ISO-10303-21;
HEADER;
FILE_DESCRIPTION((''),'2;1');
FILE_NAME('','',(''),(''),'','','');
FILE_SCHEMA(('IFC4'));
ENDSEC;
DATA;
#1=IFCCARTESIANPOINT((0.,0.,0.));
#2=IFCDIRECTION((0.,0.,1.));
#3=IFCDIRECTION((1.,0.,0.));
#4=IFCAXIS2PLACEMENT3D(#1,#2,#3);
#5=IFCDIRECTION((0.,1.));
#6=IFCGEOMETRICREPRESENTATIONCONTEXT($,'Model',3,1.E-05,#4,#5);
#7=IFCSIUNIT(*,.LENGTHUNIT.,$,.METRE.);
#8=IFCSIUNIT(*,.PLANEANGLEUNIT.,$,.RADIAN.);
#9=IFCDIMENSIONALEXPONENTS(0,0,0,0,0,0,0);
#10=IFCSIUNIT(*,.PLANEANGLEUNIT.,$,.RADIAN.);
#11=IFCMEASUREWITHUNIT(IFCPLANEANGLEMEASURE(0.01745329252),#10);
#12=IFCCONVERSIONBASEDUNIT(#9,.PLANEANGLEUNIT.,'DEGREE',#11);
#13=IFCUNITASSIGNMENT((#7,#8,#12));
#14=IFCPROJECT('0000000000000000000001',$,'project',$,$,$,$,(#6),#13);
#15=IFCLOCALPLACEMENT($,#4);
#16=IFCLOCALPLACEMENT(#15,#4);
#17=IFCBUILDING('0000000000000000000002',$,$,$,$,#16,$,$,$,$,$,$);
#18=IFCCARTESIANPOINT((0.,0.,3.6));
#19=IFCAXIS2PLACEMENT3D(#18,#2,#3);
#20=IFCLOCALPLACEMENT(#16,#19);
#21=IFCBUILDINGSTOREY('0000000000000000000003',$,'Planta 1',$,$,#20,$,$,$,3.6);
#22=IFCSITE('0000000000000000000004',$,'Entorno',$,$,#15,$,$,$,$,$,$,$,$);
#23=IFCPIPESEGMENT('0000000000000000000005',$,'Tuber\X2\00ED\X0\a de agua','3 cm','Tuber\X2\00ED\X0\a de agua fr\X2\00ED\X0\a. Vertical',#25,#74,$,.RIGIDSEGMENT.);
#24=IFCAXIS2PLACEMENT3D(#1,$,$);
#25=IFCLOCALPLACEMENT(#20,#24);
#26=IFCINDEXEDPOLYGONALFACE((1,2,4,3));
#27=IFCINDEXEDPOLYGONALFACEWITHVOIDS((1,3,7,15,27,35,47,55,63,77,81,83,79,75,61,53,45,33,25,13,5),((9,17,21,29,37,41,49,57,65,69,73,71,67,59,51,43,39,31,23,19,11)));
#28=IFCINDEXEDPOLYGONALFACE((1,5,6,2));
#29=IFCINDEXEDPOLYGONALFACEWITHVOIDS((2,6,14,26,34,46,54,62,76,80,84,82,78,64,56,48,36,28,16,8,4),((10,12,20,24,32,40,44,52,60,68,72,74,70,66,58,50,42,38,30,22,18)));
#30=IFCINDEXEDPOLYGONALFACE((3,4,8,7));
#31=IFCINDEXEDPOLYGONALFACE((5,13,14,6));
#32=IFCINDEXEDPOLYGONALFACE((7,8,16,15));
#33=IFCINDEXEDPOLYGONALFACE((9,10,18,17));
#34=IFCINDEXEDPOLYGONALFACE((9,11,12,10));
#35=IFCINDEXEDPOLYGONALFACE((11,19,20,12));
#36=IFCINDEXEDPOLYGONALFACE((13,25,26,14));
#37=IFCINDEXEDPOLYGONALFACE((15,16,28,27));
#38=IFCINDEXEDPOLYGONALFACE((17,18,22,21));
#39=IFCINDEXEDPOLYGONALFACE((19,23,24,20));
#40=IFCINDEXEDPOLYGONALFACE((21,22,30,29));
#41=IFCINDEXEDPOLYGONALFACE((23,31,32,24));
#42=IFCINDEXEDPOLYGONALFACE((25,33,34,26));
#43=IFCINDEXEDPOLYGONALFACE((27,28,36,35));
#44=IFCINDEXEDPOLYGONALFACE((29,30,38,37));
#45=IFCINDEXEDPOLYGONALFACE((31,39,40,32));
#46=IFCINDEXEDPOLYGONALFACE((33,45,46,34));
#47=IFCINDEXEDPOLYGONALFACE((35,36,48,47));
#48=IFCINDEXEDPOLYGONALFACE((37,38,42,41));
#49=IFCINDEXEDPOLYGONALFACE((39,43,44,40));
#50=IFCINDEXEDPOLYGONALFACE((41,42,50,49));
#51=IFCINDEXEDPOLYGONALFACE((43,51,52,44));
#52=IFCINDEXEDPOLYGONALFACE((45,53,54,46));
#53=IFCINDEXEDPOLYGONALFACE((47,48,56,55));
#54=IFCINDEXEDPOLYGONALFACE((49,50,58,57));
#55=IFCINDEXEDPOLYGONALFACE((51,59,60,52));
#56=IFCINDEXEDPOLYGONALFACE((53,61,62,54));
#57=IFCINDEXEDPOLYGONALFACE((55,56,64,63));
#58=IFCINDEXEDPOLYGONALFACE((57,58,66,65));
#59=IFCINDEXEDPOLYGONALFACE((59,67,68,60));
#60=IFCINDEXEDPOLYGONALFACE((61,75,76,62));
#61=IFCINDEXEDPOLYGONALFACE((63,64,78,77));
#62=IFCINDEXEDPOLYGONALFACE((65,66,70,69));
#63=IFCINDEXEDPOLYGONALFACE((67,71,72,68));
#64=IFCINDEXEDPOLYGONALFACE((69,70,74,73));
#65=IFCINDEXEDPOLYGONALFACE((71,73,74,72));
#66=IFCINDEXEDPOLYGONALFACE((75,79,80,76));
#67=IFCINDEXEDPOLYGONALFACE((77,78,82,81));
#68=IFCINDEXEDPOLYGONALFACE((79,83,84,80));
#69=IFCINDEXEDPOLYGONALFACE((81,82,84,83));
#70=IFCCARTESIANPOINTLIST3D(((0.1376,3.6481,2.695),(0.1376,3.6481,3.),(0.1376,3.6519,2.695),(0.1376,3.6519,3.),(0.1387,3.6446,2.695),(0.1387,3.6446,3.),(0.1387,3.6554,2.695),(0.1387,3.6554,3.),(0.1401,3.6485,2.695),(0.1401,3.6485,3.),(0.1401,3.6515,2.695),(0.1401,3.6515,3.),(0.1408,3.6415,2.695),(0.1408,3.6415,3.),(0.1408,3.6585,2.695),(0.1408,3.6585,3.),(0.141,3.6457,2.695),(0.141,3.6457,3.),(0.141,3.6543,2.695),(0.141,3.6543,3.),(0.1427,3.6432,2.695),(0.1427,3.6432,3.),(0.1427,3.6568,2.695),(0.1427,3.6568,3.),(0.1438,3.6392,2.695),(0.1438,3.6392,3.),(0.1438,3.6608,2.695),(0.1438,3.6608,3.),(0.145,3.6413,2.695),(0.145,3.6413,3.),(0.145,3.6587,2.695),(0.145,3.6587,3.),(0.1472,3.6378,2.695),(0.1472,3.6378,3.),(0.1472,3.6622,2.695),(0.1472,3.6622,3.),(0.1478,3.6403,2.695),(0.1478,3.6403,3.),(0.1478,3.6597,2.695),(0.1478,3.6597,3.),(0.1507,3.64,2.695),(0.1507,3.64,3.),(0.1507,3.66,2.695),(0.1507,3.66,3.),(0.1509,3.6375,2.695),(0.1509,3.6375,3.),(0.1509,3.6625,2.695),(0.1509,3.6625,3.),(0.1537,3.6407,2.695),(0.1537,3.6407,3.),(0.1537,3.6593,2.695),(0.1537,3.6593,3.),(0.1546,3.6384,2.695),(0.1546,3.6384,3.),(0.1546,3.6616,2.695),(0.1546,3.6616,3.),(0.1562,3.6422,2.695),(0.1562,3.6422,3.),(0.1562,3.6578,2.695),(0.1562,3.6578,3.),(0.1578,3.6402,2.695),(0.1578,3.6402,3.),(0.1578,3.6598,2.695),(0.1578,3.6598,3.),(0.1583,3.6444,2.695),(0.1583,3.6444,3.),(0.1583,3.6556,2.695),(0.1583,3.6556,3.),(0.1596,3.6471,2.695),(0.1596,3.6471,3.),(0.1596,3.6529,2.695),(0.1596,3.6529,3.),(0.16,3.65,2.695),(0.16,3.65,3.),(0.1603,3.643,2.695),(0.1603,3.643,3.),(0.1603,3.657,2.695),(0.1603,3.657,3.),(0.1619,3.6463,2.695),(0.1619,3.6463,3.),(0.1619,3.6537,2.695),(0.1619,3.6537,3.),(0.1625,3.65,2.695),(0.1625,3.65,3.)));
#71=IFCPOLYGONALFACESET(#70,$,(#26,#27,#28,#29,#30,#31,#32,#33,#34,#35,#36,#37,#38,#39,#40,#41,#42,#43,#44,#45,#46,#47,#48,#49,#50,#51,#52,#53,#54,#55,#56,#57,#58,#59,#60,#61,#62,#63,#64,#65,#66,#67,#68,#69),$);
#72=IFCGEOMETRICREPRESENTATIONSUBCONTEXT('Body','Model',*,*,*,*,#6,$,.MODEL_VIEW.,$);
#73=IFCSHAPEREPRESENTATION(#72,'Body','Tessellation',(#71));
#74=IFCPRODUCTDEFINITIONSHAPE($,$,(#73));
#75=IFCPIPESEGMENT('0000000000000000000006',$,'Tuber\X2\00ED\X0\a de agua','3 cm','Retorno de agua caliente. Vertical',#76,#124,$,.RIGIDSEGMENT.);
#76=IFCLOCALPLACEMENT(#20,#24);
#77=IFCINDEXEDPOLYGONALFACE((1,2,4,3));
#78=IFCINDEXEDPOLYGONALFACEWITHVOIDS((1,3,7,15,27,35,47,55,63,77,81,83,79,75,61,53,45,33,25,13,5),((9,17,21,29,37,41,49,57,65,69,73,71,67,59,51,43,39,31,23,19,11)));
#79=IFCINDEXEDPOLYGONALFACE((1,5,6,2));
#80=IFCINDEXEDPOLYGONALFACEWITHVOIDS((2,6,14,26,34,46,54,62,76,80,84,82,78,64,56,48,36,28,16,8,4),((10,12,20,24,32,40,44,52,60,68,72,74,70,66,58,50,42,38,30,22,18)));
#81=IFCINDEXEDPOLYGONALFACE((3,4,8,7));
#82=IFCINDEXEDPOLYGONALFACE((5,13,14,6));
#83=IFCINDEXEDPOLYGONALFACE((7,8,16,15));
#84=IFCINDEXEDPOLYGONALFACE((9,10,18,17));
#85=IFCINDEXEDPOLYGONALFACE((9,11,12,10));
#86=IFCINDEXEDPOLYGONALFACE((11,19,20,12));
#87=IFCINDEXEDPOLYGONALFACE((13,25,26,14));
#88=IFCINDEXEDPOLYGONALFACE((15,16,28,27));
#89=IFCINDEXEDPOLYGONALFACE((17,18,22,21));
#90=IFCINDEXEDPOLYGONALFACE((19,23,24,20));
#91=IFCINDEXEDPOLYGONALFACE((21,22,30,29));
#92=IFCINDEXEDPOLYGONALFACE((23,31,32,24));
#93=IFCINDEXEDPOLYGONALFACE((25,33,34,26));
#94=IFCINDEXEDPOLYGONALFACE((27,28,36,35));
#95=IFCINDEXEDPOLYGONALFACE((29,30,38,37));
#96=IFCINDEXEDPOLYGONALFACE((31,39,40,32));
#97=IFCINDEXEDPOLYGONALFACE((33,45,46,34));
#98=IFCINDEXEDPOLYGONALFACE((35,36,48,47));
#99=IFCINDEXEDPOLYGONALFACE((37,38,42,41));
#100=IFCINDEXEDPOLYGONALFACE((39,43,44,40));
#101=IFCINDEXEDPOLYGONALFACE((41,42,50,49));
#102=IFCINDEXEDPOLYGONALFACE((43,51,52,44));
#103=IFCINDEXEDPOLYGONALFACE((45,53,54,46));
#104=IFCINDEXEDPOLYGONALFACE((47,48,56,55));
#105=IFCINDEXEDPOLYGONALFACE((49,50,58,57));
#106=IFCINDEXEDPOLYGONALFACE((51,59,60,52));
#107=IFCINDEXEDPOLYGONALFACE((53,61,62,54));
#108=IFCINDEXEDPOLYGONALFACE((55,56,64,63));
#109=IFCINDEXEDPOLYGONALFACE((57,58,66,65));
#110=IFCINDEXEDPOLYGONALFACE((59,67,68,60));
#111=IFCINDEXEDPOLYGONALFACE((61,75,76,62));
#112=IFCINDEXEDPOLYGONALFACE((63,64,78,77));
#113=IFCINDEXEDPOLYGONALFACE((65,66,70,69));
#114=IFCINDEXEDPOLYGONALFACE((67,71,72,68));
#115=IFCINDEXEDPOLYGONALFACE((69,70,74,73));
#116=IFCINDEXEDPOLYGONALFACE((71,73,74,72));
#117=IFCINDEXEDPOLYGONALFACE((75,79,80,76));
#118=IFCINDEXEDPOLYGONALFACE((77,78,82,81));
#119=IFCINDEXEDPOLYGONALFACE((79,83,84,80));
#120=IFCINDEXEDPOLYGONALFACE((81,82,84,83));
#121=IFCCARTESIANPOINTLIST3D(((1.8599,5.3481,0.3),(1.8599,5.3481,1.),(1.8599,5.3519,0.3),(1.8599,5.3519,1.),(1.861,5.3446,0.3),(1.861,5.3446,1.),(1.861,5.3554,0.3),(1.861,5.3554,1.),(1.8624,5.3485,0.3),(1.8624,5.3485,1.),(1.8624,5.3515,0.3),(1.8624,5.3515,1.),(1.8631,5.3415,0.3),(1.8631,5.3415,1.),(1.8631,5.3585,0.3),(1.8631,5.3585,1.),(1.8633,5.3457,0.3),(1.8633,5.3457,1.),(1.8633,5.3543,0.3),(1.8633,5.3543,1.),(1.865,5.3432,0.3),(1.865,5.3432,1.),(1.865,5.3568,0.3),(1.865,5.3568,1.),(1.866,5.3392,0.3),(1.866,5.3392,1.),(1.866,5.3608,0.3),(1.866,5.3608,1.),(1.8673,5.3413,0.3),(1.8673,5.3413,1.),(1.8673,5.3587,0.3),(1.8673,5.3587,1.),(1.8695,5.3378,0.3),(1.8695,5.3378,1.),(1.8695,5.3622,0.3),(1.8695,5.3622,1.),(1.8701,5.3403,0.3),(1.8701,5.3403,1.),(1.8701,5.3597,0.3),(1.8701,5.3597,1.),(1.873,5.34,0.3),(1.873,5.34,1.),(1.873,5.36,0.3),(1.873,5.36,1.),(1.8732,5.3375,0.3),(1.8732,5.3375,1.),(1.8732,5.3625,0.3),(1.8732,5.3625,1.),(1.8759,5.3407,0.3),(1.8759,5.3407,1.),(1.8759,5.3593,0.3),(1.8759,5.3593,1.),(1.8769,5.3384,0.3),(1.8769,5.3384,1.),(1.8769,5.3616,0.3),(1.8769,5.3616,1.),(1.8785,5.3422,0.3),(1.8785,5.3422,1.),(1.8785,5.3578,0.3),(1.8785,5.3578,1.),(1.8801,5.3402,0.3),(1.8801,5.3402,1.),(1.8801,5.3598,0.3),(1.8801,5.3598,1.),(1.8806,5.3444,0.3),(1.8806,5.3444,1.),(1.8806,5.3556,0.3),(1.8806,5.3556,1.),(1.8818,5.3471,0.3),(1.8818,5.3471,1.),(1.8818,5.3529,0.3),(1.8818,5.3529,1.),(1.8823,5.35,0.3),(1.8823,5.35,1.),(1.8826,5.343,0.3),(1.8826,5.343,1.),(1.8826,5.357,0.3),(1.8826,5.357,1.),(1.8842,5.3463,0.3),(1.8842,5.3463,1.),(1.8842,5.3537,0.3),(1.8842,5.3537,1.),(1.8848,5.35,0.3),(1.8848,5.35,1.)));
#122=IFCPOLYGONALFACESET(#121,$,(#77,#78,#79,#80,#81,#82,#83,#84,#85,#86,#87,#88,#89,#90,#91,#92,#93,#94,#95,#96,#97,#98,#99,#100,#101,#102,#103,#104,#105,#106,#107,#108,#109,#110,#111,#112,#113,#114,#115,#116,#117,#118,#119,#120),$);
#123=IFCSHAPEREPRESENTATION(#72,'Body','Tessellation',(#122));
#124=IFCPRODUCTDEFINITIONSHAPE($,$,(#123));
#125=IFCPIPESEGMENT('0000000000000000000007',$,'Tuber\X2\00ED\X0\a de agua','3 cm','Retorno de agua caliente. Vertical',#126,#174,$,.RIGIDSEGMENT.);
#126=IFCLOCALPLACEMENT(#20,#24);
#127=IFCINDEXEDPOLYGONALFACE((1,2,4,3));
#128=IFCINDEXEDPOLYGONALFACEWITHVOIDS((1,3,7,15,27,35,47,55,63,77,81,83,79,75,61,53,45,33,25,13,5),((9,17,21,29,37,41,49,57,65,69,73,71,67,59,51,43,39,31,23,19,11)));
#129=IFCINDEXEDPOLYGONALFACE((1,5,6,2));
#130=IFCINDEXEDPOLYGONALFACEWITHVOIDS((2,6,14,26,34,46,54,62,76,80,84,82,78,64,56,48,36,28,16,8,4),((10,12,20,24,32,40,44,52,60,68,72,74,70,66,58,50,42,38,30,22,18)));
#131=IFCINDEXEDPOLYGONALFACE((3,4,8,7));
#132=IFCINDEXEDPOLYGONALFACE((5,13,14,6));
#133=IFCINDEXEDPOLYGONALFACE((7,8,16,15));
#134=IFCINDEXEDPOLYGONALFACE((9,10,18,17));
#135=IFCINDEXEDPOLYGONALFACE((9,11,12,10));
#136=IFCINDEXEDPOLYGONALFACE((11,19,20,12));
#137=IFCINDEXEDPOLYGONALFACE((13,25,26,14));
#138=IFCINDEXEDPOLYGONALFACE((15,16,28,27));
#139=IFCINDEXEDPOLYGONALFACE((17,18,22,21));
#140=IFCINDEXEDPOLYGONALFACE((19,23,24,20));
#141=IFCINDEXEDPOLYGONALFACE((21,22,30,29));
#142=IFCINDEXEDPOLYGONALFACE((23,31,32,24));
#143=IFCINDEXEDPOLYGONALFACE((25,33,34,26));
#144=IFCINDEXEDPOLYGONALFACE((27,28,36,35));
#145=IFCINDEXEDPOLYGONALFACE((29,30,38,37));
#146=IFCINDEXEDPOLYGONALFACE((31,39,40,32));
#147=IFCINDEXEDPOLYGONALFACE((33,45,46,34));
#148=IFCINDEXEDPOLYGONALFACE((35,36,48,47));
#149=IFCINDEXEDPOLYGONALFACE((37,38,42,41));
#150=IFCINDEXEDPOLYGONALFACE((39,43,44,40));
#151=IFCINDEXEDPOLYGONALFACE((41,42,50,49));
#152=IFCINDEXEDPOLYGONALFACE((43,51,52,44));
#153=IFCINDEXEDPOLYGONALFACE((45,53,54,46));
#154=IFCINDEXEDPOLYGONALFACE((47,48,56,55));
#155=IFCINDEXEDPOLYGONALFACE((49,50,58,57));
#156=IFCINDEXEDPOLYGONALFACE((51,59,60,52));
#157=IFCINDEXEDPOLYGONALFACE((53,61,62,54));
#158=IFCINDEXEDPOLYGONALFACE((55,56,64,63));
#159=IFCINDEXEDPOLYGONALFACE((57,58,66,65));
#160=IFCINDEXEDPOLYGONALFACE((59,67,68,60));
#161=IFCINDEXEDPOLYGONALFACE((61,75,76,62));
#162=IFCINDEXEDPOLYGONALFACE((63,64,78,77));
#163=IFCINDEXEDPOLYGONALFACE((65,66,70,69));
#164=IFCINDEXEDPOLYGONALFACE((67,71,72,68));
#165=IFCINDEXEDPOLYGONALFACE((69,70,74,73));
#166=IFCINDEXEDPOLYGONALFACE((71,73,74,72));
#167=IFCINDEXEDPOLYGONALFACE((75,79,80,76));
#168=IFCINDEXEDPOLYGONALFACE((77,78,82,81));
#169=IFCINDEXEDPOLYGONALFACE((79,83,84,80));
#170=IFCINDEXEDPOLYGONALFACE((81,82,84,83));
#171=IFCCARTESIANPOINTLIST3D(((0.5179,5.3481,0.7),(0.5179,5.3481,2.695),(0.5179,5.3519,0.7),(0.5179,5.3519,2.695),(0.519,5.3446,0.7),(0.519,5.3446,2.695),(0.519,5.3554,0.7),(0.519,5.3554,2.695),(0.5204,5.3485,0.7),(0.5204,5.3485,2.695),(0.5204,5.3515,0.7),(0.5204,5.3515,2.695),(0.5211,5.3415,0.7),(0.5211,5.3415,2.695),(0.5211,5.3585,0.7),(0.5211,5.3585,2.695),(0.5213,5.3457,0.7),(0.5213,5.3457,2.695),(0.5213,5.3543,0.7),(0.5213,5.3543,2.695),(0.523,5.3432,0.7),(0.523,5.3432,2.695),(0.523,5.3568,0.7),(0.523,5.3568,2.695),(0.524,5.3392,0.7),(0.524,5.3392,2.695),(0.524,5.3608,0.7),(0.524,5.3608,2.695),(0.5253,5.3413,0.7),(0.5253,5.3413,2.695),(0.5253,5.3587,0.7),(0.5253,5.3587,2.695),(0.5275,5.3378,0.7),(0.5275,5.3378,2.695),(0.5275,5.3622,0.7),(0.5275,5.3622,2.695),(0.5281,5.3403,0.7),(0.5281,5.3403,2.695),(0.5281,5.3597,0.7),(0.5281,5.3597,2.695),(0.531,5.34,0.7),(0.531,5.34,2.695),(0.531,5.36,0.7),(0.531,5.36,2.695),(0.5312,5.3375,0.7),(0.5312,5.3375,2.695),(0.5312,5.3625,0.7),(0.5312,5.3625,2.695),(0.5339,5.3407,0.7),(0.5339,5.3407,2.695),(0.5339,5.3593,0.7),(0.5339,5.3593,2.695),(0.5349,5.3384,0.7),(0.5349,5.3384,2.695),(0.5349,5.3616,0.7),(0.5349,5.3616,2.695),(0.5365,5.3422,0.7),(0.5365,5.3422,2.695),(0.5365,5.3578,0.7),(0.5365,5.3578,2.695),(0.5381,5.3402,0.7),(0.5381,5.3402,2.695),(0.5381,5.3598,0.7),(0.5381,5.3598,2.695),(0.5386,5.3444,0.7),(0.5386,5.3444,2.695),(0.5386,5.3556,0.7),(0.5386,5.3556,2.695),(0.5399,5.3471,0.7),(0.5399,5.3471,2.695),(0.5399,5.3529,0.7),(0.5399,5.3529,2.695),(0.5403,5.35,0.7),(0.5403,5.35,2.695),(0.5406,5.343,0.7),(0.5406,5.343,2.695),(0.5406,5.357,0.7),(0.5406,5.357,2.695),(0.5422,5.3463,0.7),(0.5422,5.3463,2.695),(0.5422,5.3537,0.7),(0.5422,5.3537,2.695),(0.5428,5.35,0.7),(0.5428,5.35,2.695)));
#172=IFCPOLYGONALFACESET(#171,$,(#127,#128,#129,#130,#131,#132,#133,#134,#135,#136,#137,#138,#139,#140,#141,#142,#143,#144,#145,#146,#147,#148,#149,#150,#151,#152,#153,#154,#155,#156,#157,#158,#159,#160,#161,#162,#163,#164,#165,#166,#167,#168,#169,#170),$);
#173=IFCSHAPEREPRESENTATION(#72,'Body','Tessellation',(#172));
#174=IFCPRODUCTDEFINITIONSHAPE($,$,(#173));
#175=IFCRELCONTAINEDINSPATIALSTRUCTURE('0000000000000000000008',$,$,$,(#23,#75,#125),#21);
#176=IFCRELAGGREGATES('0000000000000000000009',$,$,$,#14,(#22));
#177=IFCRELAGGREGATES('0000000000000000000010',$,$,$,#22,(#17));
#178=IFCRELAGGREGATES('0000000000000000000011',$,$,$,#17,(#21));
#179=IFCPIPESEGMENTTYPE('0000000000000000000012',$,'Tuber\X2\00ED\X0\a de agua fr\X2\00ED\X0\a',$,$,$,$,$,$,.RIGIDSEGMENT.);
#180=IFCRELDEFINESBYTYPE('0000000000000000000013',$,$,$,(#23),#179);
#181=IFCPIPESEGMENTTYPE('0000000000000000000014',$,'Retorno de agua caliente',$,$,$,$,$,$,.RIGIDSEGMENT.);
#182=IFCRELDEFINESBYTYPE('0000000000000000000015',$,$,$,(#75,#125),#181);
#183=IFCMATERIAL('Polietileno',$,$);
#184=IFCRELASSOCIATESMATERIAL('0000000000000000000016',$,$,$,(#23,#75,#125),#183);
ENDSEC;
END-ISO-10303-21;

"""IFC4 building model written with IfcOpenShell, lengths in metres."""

from ifc_helpers import new_model, entity, si_unit, converted_unit, direction, frame, origin_with_axes, origin_2d_with_axis, place, context, subcontext, project, spatial, hollow_circle, extrude, material, type_object, element, save


model = new_model("IFC4")

# Units and contexts
model_context = context("Model", 3, precision=1e-05, world=origin_with_axes(), true_north=direction((0.0, 1.0)))
body_context = subcontext(model_context, "Body", "Model", "MODEL_VIEW")
ifc_project = project(units=[si_unit("LENGTHUNIT", "METRE"), si_unit("PLANEANGLEUNIT", "RADIAN"), converted_unit("PLANEANGLEUNIT", "DEGREE", entity("IfcPlaneAngleMeasure", 0.01745329252), si_unit("PLANEANGLEUNIT", "RADIAN"), dimensions=[0, 0, 0, 0, 0, 0, 0])], contexts=[model_context])

# Site, building, storey
site_placement = place(None, origin_with_axes())
site = spatial("IfcSite", under=ifc_project, at=site_placement, Name="Entorno")
building_placement = place(site_placement, origin_with_axes())
building = spatial("IfcBuilding", under=site, at=building_placement)
storey_placement = place(building_placement, frame((0.0, 0.0, 3.6), z_axis=(0.0, 0.0, 1.0), x_axis=(1.0, 0.0, 0.0)))
storey = spatial("IfcBuildingStorey", under=building, at=storey_placement, Name="Planta 1", Elevation=3.6)

# Pipe segments
ifc_material_1 = material(Name="Polietileno")
pipe_segment_type_1 = type_object("IfcPipeSegmentType", Name="Tubería de agua fría", PredefinedType="RIGIDSEGMENT")
pipe_segment_1_placement = place(storey_placement, frame((0.15, 3.65, 2.695), z_axis=(0.0, 0.0, 1.0), x_axis=(1.0, 0.0, 0.0)))
element("IfcPipeSegment", 1, at=pipe_segment_1_placement, inside=storey, type_object=pipe_segment_type_1, material=ifc_material_1, Name="Tubería de agua", Description="3 cm", ObjectType="Tubería de agua fría. Vertical", PredefinedType="RIGIDSEGMENT", context=body_context, shape_type="SweptSolid", body=[
    extrude(hollow_circle(Radius=0.0125, WallThickness=0.0025, at=origin_2d_with_axis()), origin_with_axes(), (0.0, 0.0, 1.0), 0.305),
])
pipe_segment_type_2 = type_object("IfcPipeSegmentType", Name="Retorno de agua caliente", PredefinedType="RIGIDSEGMENT")
pipe_segment_2_placement = place(storey_placement, frame((1.8723, 5.35, 1.0), z_axis=(0.0, 0.0, -1.0), x_axis=(1.0, 0.0, 0.0)))
element("IfcPipeSegment", 2, at=pipe_segment_2_placement, inside=storey, type_object=pipe_segment_type_2, material=ifc_material_1, Name="Tubería de agua", Description="3 cm", ObjectType="Retorno de agua caliente. Vertical", PredefinedType="RIGIDSEGMENT", context=body_context, shape_type="SweptSolid", body=[
    extrude(hollow_circle(Radius=0.0125, WallThickness=0.0025, at=origin_2d_with_axis()), origin_with_axes(), (0.0, 0.0, 1.0), 0.7),
])
pipe_segment_3_placement = place(storey_placement, frame((0.5303, 5.35, 2.695), z_axis=(0.0, 0.0, -1.0), x_axis=(1.0, 0.0, 0.0)))
element("IfcPipeSegment", 3, at=pipe_segment_3_placement, inside=storey, type_object=pipe_segment_type_2, material=ifc_material_1, Name="Tubería de agua", Description="3 cm", ObjectType="Retorno de agua caliente. Vertical", PredefinedType="RIGIDSEGMENT", context=body_context, shape_type="SweptSolid", body=[
    extrude(hollow_circle(Radius=0.0125, WallThickness=0.0025, at=origin_2d_with_axis()), origin_with_axes(), (0.0, 0.0, 1.0), 1.995),
])

save(model, "model.ifc")
